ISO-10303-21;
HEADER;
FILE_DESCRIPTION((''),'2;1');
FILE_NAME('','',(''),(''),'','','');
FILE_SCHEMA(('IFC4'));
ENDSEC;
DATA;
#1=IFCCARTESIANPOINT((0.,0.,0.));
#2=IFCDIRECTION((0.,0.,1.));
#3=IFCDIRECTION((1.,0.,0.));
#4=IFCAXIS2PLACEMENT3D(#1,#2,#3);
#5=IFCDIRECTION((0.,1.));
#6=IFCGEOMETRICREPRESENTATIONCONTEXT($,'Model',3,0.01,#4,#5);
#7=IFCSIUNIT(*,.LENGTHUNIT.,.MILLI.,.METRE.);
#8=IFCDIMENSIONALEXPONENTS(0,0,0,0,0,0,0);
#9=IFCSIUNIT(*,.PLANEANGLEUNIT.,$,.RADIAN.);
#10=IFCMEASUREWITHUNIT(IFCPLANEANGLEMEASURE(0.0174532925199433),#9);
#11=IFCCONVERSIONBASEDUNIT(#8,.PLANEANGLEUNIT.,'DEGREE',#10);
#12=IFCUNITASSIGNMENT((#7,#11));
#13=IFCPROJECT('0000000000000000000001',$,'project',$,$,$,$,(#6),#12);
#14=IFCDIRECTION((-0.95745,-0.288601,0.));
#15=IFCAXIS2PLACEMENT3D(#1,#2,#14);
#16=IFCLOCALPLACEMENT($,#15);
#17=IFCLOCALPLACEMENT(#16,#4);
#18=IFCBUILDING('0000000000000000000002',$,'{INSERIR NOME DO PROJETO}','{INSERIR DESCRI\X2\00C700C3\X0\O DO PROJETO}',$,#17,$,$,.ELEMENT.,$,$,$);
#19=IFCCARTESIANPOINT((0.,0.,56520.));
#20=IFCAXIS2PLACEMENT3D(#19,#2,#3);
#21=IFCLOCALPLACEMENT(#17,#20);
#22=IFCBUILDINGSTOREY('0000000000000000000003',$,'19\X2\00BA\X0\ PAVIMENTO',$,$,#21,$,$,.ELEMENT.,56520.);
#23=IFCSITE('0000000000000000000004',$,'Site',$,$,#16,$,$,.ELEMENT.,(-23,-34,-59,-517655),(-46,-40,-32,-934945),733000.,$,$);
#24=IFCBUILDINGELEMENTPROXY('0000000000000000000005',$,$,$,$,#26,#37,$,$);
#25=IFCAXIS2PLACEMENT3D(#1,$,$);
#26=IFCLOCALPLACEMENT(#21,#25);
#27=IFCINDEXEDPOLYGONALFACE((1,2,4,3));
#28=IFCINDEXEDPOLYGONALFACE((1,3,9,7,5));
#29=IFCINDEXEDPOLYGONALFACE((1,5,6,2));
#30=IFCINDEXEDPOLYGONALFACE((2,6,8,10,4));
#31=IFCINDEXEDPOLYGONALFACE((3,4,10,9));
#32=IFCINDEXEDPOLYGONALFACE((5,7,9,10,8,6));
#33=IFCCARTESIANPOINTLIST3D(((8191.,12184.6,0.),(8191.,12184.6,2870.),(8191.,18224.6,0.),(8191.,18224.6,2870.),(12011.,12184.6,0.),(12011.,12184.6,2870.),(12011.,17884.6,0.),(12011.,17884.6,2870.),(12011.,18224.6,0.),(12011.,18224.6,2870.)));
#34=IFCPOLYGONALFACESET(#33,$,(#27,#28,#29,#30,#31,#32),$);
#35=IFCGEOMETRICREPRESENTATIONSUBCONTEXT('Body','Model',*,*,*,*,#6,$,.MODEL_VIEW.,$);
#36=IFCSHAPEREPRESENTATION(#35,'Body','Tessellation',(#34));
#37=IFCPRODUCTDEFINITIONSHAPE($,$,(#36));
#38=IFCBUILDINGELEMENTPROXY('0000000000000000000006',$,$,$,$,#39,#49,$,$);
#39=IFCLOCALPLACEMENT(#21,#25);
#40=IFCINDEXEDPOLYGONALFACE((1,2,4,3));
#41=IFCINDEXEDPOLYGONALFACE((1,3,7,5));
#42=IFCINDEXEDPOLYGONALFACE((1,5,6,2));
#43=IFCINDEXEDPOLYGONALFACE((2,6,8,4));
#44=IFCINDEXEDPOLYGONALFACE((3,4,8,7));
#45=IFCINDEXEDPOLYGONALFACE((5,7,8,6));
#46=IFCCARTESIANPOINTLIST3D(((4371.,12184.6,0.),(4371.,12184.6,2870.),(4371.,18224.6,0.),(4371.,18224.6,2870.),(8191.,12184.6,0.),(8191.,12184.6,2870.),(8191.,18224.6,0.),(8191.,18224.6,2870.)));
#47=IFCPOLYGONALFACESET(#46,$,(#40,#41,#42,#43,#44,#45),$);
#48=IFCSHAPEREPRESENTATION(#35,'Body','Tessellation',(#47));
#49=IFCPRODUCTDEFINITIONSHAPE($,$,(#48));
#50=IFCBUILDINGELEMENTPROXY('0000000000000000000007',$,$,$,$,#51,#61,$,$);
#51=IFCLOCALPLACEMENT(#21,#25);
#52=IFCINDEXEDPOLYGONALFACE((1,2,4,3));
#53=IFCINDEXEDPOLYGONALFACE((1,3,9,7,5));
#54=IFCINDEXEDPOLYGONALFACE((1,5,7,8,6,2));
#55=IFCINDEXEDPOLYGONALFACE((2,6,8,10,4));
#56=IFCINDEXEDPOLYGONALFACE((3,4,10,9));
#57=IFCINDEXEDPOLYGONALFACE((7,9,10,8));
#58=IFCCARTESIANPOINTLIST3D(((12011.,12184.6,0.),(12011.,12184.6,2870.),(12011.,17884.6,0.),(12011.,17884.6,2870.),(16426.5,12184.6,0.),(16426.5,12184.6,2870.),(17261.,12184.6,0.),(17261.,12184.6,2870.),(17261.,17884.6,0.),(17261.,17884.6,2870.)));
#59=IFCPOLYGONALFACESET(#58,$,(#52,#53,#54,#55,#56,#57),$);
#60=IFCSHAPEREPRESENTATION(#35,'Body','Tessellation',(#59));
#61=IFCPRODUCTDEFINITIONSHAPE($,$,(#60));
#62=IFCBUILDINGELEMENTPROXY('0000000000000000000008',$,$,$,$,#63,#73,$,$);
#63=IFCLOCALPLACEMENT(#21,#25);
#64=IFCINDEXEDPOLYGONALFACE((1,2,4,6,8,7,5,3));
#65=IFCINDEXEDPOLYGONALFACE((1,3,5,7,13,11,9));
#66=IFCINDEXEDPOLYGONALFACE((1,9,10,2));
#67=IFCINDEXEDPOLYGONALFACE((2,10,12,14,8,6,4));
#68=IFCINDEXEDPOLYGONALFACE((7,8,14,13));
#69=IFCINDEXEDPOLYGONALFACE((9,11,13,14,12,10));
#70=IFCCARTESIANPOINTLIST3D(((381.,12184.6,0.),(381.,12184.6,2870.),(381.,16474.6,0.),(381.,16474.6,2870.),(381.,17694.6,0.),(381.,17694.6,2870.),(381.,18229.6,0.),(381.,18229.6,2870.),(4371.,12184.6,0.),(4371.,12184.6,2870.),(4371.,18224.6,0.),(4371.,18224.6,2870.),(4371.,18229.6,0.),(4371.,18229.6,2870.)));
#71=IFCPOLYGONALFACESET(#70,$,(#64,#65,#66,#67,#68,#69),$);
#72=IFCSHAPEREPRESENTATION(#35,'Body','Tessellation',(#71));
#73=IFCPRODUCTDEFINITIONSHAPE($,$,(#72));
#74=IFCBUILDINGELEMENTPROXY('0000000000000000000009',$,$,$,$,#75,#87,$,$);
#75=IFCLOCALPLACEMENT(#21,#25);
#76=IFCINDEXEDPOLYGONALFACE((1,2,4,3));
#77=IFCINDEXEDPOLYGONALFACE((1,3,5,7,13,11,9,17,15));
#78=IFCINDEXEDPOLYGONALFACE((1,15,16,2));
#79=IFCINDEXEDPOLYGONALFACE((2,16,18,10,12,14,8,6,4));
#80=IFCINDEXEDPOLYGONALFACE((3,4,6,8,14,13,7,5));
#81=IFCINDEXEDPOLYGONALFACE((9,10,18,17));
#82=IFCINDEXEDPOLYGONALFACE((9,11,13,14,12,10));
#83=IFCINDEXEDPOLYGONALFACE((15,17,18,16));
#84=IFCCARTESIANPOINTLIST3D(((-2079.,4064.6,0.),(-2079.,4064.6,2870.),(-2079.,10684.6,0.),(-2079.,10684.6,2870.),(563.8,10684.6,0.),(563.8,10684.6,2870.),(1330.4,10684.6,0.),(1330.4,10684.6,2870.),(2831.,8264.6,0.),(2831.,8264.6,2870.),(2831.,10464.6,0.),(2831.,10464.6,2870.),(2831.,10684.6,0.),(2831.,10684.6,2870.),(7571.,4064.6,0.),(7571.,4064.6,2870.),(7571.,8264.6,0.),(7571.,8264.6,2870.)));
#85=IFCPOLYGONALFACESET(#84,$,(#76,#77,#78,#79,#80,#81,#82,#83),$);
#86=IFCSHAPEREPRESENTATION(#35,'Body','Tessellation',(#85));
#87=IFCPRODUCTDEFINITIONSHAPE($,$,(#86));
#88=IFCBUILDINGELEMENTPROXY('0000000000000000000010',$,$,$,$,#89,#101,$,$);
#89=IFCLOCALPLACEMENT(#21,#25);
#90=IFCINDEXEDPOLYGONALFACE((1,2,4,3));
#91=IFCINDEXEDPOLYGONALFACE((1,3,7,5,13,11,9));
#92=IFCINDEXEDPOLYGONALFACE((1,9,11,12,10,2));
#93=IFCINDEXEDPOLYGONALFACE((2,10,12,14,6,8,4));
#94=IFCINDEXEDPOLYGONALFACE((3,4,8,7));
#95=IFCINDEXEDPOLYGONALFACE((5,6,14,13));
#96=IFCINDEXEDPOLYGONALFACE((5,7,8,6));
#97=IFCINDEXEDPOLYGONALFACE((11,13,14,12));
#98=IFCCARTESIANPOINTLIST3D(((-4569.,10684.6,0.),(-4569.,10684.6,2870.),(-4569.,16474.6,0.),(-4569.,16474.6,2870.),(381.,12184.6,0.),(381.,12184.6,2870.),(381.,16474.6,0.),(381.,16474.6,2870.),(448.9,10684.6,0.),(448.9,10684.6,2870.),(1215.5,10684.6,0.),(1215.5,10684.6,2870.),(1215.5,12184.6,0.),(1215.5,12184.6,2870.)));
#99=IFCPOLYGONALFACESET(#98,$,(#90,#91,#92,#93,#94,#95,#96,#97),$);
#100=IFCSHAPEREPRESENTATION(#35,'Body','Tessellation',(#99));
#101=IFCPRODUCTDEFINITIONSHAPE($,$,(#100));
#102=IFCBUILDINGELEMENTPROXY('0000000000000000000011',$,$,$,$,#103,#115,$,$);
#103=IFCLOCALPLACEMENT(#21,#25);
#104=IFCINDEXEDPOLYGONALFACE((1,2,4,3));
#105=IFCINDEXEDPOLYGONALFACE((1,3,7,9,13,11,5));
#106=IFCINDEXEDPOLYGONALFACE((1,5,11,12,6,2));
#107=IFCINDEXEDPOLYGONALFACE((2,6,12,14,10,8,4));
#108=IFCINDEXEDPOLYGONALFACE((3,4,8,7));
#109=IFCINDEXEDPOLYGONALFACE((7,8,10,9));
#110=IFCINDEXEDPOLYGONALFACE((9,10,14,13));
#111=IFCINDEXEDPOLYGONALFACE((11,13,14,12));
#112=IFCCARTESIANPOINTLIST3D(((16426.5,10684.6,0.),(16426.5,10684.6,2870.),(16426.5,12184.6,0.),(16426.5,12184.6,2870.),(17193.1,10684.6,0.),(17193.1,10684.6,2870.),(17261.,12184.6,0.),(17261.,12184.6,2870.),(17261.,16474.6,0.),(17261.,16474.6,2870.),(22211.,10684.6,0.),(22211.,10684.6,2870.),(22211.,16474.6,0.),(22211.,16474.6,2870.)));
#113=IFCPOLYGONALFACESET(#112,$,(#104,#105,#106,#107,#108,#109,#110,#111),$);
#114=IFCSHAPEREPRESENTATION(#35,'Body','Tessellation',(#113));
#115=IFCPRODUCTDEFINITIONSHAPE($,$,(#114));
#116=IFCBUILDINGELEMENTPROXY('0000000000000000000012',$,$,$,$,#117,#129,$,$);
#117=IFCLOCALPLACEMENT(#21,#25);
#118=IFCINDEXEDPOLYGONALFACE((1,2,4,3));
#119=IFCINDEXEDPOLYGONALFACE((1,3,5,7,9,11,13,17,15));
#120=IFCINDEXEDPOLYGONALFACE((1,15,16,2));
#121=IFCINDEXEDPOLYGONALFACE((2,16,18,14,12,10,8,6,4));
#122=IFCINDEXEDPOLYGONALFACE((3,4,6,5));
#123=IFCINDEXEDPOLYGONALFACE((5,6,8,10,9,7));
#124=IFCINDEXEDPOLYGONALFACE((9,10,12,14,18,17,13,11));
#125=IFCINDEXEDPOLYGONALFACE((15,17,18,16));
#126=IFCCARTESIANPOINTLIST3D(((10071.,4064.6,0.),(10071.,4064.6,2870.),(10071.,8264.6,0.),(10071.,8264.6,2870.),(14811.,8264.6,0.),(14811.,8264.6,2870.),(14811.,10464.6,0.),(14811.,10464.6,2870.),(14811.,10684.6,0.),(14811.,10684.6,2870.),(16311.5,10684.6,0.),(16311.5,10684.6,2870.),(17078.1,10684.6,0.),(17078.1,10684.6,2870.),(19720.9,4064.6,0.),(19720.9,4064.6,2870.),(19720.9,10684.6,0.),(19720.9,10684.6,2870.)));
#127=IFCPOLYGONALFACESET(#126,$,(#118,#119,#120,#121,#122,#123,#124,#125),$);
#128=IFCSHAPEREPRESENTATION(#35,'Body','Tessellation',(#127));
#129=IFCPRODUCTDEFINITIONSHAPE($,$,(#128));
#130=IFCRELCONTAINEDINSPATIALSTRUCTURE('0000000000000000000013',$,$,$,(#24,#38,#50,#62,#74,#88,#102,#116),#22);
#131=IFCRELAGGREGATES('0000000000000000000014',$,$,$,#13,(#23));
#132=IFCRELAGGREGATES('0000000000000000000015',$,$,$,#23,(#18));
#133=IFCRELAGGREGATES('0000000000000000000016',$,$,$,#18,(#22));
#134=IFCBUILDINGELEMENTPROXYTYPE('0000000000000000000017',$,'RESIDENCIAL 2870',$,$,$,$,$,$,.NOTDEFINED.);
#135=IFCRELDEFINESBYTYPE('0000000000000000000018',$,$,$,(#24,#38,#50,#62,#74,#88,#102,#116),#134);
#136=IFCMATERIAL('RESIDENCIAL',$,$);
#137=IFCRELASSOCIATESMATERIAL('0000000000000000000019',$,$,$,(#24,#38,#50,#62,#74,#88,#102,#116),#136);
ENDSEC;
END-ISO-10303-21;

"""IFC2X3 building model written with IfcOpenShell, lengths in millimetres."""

from ifc_helpers import new_model, entity, si_unit, converted_unit, direction, frame, origin_with_axes, place, context, subcontext, project, spatial, polyline, outline, extrude, material, type_object, element, save


model = new_model("IFC2X3")

# Units and contexts
model_context = context("Model", 3, precision=0.01, world=origin_with_axes(), true_north=direction((0.0, 1.0)))
body_context = subcontext(model_context, "Body", "Model", "MODEL_VIEW")
ifc_project = project(units=[si_unit("LENGTHUNIT", "METRE", prefix="MILLI"), converted_unit("PLANEANGLEUNIT", "DEGREE", entity("IfcPlaneAngleMeasure", 0.0174532925199433), si_unit("PLANEANGLEUNIT", "RADIAN"), dimensions=[0, 0, 0, 0, 0, 0, 0])], contexts=[model_context])

# Site, building, storey
site_placement = place(None, frame((0.0, 0.0, 0.0), z_axis=(0.0, 0.0, 1.0), x_axis=(-0.95745, -0.288601, 0.0)))
site = spatial("IfcSite", under=ifc_project, at=site_placement, Name="Site", CompositionType="ELEMENT", RefLatitude=(-23, -34, -59, -517655), RefLongitude=(-46, -40, -32, -934945), RefElevation=733000.0)
building_placement = place(site_placement, origin_with_axes())
building = spatial("IfcBuilding", under=site, at=building_placement, Name="{INSERIR NOME DO PROJETO}", Description="{INSERIR DESCRIÇÃO DO PROJETO}", CompositionType="ELEMENT")
storey_placement = place(building_placement, frame((0.0, 0.0, 56520.0), z_axis=(0.0, 0.0, 1.0), x_axis=(1.0, 0.0, 0.0)))
storey = spatial("IfcBuildingStorey", under=building, at=storey_placement, Name="19º PAVIMENTO", CompositionType="ELEMENT", Elevation=56520.0)

# Building element proxies
ifc_material_1 = material(Name="RESIDENCIAL")
building_element_proxy_type_1 = type_object("IfcBuildingElementProxyType", Name="RESIDENCIAL 2870", PredefinedType="NOTDEFINED")
proxy_1_placement = place(storey_placement, frame((8191.0, 18224.6, 0.0), z_axis=(0.0, 0.0, 1.0), x_axis=(1.0, 0.0, 0.0)))
element("IfcBuildingElementProxy", 1, at=proxy_1_placement, inside=storey, type_object=building_element_proxy_type_1, material=ifc_material_1, context=body_context, shape_type="SweptSolid", body=[
    extrude(outline(polyline([(0.0, 0.0), (0.0, -6040.0), (3820.0, -6040.0), (3820.0, -340.0), (3820.0, 0.0), (0.0, 0.0)])), origin_with_axes(), (0.0, 0.0, 1.0), 2870.0),
])
proxy_2_placement = place(storey_placement, frame((4371.0, 18224.6, 0.0), z_axis=(0.0, 0.0, 1.0), x_axis=(1.0, 0.0, 0.0)))
element("IfcBuildingElementProxy", 2, at=proxy_2_placement, inside=storey, type_object=building_element_proxy_type_1, material=ifc_material_1, context=body_context, shape_type="SweptSolid", body=[
    extrude(outline(polyline([(0.0, 0.0), (0.0, -6040.0), (3820.0, -6040.0), (3820.0, 0.0), (0.0, 0.0)])), origin_with_axes(), (0.0, 0.0, 1.0), 2870.0),
])
proxy_3_placement = place(storey_placement, frame((12011.0, 12184.6, 0.0), z_axis=(0.0, 0.0, 1.0), x_axis=(1.0, 0.0, 0.0)))
element("IfcBuildingElementProxy", 3, at=proxy_3_placement, inside=storey, type_object=building_element_proxy_type_1, material=ifc_material_1, context=body_context, shape_type="SweptSolid", body=[
    extrude(outline(polyline([(0.0, 0.0), (4415.5, 0.0), (5250.0, 0.0), (5250.0, 5700.0), (0.0, 5700.0), (0.0, 0.0)])), origin_with_axes(), (0.0, 0.0, 1.0), 2870.0),
])
proxy_4_placement = place(storey_placement, frame((381.0, 16474.6, 0.0), z_axis=(0.0, 0.0, 1.0), x_axis=(1.0, 0.0, 0.0)))
element("IfcBuildingElementProxy", 4, at=proxy_4_placement, inside=storey, type_object=building_element_proxy_type_1, material=ifc_material_1, context=body_context, shape_type="SweptSolid", body=[
    extrude(outline(polyline([(0.0, 0.0), (0.0, -4290.0), (3990.0, -4290.0), (3990.0, 1750.0), (3990.0, 1755.0), (0.0, 1755.0), (0.0, 1220.0), (0.0, 0.0)])), origin_with_axes(), (0.0, 0.0, 1.0), 2870.0),
])
proxy_5_placement = place(storey_placement, frame((-2079.0, 4064.6, 0.0), z_axis=(0.0, 0.0, 1.0), x_axis=(1.0, 0.0, 0.0)))
element("IfcBuildingElementProxy", 5, at=proxy_5_placement, inside=storey, type_object=building_element_proxy_type_1, material=ifc_material_1, context=body_context, shape_type="SweptSolid", body=[
    extrude(outline(polyline([(0.0, 0.0), (9650.0, 0.0), (9650.0, 4200.0), (4910.0, 4200.0), (4910.0, 6400.0), (4910.0, 6620.0), (3409.4, 6620.0), (2642.8, 6620.0), (0.0, 6620.0), (0.0, 0.0)])), origin_with_axes(), (0.0, 0.0, 1.0), 2870.0),
])
proxy_6_placement = place(storey_placement, frame((-4569.0, 16474.6, 0.0), z_axis=(0.0, 0.0, 1.0), x_axis=(1.0, 0.0, 0.0)))
element("IfcBuildingElementProxy", 6, at=proxy_6_placement, inside=storey, type_object=building_element_proxy_type_1, material=ifc_material_1, context=body_context, shape_type="SweptSolid", body=[
    extrude(outline(polyline([(0.0, 0.0), (0.0, -5790.0), (5017.9, -5790.0), (5784.5, -5790.0), (5784.5, -4290.0), (4950.0, -4290.0), (4950.0, 0.0), (0.0, 0.0)])), origin_with_axes(), (0.0, 0.0, 1.0), 2870.0),
])
proxy_7_placement = place(storey_placement, frame((17261.0, 12184.6, 0.0), z_axis=(0.0, 0.0, 1.0), x_axis=(1.0, 0.0, 0.0)))
element("IfcBuildingElementProxy", 7, at=proxy_7_placement, inside=storey, type_object=building_element_proxy_type_1, material=ifc_material_1, context=body_context, shape_type="SweptSolid", body=[
    extrude(outline(polyline([(0.0, 0.0), (-834.5, 0.0), (-834.5, -1500.0), (-67.9, -1500.0), (4950.0, -1500.0), (4950.0, 4290.0), (0.0, 4290.0), (0.0, 0.0)])), origin_with_axes(), (0.0, 0.0, 1.0), 2870.0),
])
proxy_8_placement = place(storey_placement, frame((19720.9, 4064.6, 0.0), z_axis=(0.0, 0.0, 1.0), x_axis=(1.0, 0.0, 0.0)))
element("IfcBuildingElementProxy", 8, at=proxy_8_placement, inside=storey, type_object=building_element_proxy_type_1, material=ifc_material_1, context=body_context, shape_type="SweptSolid", body=[
    extrude(outline(polyline([(0.0, 0.0), (0.0, 6620.0), (-2642.8, 6620.0), (-3409.4, 6620.0), (-4910.0, 6620.0), (-4910.0, 6400.0), (-4910.0, 4200.0), (-9650.0, 4200.0), (-9650.0, 0.0), (0.0, 0.0)])), origin_with_axes(), (0.0, 0.0, 1.0), 2870.0),
])

save(model, "model.ifc")
